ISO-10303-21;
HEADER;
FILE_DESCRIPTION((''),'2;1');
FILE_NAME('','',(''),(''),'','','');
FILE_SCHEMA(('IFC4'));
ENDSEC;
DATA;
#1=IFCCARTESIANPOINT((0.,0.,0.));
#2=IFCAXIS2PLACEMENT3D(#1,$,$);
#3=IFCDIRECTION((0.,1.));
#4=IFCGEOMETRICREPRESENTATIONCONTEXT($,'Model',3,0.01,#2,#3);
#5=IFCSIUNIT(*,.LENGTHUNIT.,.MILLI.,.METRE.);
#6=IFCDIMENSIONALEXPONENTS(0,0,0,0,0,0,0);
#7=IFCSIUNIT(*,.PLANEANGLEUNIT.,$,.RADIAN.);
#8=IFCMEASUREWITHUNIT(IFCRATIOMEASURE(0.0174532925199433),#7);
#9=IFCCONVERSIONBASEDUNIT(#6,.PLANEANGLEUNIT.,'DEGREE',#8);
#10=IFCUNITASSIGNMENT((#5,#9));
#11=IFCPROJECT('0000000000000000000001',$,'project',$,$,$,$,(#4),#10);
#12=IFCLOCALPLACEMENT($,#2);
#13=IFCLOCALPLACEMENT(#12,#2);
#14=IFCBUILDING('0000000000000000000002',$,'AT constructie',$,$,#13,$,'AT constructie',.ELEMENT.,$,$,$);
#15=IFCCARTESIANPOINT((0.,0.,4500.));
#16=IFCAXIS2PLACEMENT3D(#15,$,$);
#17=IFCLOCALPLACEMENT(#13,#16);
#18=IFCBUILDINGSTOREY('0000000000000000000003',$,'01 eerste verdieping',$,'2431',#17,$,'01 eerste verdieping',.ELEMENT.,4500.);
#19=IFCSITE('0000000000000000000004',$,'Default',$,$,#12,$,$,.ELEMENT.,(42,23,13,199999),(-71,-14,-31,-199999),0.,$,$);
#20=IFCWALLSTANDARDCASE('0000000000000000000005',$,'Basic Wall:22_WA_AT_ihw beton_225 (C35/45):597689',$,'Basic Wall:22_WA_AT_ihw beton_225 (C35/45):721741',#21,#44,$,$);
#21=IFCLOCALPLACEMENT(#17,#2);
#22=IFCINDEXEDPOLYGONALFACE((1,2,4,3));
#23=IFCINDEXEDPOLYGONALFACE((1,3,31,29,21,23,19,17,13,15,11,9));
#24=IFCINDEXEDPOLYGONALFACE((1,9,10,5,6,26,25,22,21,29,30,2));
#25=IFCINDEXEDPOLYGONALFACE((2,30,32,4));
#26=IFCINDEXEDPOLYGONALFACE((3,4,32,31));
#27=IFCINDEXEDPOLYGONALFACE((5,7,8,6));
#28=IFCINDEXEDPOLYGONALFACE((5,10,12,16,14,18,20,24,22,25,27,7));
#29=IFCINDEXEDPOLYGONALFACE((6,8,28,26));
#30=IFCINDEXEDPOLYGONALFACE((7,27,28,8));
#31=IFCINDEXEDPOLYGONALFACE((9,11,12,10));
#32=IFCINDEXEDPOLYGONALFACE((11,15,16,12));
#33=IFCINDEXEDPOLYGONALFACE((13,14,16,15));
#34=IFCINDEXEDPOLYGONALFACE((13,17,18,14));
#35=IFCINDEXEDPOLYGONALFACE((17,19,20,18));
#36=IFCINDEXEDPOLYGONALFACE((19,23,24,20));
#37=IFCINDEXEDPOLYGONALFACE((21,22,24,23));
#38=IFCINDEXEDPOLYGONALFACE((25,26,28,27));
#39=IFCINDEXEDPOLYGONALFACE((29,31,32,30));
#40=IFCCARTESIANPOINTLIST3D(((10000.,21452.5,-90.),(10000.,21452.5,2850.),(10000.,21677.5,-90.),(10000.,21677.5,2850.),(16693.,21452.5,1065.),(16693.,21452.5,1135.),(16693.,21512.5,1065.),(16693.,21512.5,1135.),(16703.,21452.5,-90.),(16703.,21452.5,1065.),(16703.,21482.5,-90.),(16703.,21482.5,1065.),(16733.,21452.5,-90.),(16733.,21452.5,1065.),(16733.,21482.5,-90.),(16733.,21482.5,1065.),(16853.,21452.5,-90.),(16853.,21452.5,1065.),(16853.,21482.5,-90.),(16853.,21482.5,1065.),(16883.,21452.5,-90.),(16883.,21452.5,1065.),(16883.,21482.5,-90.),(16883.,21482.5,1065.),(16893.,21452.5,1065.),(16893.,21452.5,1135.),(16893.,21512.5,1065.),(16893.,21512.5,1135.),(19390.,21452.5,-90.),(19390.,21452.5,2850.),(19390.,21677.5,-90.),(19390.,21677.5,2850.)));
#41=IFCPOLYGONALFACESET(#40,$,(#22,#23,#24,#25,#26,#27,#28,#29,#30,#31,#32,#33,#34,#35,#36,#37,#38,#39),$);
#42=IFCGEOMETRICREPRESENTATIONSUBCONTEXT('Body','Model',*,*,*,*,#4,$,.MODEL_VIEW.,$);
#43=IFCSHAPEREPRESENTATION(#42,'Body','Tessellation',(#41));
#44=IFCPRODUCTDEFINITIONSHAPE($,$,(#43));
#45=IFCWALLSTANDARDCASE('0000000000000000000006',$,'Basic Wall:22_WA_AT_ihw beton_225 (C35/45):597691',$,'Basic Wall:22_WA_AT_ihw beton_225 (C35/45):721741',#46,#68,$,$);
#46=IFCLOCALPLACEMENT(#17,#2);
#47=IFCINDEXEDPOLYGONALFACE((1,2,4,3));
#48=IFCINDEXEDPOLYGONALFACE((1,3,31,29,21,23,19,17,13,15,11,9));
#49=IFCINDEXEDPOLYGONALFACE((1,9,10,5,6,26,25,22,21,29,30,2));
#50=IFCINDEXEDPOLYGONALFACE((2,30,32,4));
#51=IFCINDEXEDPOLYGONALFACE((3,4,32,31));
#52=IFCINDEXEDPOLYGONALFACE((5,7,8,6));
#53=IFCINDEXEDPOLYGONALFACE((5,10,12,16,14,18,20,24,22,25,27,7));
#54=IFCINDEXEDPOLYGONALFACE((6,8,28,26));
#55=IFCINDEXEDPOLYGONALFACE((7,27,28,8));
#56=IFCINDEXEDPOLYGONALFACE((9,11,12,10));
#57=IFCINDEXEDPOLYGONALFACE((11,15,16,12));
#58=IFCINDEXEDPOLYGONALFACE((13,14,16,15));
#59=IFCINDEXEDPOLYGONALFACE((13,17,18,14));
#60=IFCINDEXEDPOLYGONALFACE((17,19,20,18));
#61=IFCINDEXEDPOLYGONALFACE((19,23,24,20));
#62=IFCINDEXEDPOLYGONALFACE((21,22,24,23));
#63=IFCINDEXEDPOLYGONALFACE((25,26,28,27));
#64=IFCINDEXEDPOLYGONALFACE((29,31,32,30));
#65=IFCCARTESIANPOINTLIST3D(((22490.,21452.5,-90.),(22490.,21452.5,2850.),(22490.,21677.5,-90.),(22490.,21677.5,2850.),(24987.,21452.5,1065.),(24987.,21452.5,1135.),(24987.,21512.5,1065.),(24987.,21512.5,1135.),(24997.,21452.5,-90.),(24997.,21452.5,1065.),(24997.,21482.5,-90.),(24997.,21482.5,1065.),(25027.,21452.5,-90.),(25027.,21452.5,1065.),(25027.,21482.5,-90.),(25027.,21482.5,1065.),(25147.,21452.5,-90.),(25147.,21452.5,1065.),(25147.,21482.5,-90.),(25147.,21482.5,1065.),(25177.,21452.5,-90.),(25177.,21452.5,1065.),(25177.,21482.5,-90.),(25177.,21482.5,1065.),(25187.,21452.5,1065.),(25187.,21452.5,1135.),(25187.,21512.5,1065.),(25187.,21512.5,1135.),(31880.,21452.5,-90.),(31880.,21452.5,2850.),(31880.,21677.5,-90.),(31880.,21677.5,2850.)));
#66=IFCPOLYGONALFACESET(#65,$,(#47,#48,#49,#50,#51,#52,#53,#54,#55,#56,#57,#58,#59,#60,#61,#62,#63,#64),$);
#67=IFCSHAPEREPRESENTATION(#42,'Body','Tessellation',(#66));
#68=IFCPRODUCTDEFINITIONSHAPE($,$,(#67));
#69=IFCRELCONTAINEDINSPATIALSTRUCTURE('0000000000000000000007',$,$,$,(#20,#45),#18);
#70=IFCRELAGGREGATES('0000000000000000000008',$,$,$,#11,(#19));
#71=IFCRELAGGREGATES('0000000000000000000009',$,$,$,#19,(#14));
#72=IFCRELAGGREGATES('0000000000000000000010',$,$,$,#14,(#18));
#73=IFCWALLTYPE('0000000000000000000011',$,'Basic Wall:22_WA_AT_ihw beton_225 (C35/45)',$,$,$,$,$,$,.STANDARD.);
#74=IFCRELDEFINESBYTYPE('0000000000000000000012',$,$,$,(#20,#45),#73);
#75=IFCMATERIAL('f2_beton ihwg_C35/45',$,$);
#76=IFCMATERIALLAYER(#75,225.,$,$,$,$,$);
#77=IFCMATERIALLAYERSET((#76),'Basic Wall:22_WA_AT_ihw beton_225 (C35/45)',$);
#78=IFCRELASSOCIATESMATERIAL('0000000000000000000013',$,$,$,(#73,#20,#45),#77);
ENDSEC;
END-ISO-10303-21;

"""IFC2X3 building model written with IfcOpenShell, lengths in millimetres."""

from ifc_helpers import new_model, entity, si_unit, converted_unit, direction, frame, frame_2d, origin, origin_2d_with_axis, place, context, subcontext, project, spatial, rectangle, extrude, material, layer, layer_set, layer_usage, type_object, element, save


model = new_model("IFC2X3")

# Units and contexts
model_context = context("Model", 3, precision=0.01, world=origin(), true_north=direction((0.0, 1.0)))
body_context = subcontext(model_context, "Body", "Model", "MODEL_VIEW")
ifc_project = project(units=[si_unit("LENGTHUNIT", "METRE", prefix="MILLI"), converted_unit("PLANEANGLEUNIT", "DEGREE", entity("IfcRatioMeasure", 0.0174532925199433), si_unit("PLANEANGLEUNIT", "RADIAN"), dimensions=[0, 0, 0, 0, 0, 0, 0])], contexts=[model_context])

# Site, building, storey
site_placement = place(None, origin())
site = spatial("IfcSite", under=ifc_project, at=site_placement, Name="Default", CompositionType="ELEMENT", RefLatitude=(42, 23, 13, 199999), RefLongitude=(-71, -14, -31, -199999), RefElevation=0.0)
building_placement = place(site_placement, origin())
building = spatial("IfcBuilding", under=site, at=building_placement, Name="AT constructie", LongName="AT constructie", CompositionType="ELEMENT")
storey_placement = place(building_placement, frame((0.0, 0.0, 4500.0)))
storey = spatial("IfcBuildingStorey", under=building, at=storey_placement, Name="01 eerste verdieping", ObjectType="2431", LongName="01 eerste verdieping", CompositionType="ELEMENT", Elevation=4500.0)

# Shared definitions
ifc_material_1 = material(Name="f2_beton ihwg_C35/45")

# Shared definitions
ifc_layer_1 = layer(ifc_material_1, 225.0)
ifc_layer_set_1 = layer_set([ifc_layer_1], Name="Basic Wall:22_WA_AT_ihw beton_225 (C35/45)")
wall_type_1 = type_object("IfcWallType", Name="Basic Wall:22_WA_AT_ihw beton_225 (C35/45)", PredefinedType="STANDARD", material=ifc_layer_set_1)

# Walls, openings
ifc_layer_usage_1 = layer_usage(ifc_layer_set_1, "AXIS2", "NEGATIVE", 112.5)
wall_1_placement = place(storey_placement, frame((10000.0, 21565.0, -90.0)))
wall_1 = element("IfcWallStandardCase", 1, at=wall_1_placement, inside=storey, type_object=wall_type_1, material=ifc_layer_usage_1, Name="Basic Wall:22_WA_AT_ihw beton_225 (C35/45):597689", ObjectType="Basic Wall:22_WA_AT_ihw beton_225 (C35/45):721741", context=body_context, shape_type="SweptSolid", body=[
    extrude(rectangle(XDim=9390.0, YDim=225.0, at=frame_2d((4695.0, 0.0), x_axis=(-1.0, 0.0))), origin(), (0.0, 0.0, 1.0), 2940.0),
])
opening_1_placement = place(wall_1_placement, origin())
element("IfcOpeningElement", 2, at=opening_1_placement, cuts=wall_1, ObjectType="Recess", context=body_context, shape_type="SweptSolid", body=[
    extrude(rectangle(XDim=1155.0, YDim=30.0, at=frame_2d((0.0, 0.0), x_axis=(1.0, 0.0))), frame((6718.0, -112.5, 577.5), z_axis=(0.0, 1.0, 0.0), x_axis=(0.0, 0.0, -1.0)), (0.0, 0.0, 1.0), 30.0),
])
opening_2_placement = place(wall_1_placement, origin())
element("IfcOpeningElement", 3, at=opening_2_placement, cuts=wall_1, ObjectType="Recess", context=body_context, shape_type="SweptSolid", body=[
    extrude(rectangle(XDim=1155.0, YDim=30.0, at=frame_2d((0.0, 0.0), x_axis=(1.0, 0.0))), frame((6868.0, -112.5, 577.5), z_axis=(0.0, 1.0, 0.0), x_axis=(0.0, 0.0, -1.0)), (0.0, 0.0, 1.0), 30.0),
])
opening_3_placement = place(wall_1_placement, origin())
element("IfcOpeningElement", 4, at=opening_3_placement, cuts=wall_1, ObjectType="Recess", context=body_context, shape_type="SweptSolid", body=[
    extrude(rectangle(XDim=70.0, YDim=200.0, at=origin_2d_with_axis()), frame((6793.0, -112.5, 1190.0), z_axis=(0.0, 1.0, 0.0), x_axis=(0.0, 0.0, -1.0)), (0.0, 0.0, 1.0), 60.0),
])
ifc_layer_usage_2 = layer_usage(ifc_layer_set_1, "AXIS2", "NEGATIVE", 112.5)
wall_2_placement = place(storey_placement, frame((22490.0, 21565.0, -90.0)))
wall_2 = element("IfcWallStandardCase", 5, at=wall_2_placement, inside=storey, type_object=wall_type_1, material=ifc_layer_usage_2, Name="Basic Wall:22_WA_AT_ihw beton_225 (C35/45):597691", ObjectType="Basic Wall:22_WA_AT_ihw beton_225 (C35/45):721741", context=body_context, shape_type="SweptSolid", body=[
    extrude(rectangle(XDim=9390.0, YDim=225.0, at=frame_2d((4695.0, 0.0), x_axis=(-1.0, 0.0))), origin(), (0.0, 0.0, 1.0), 2940.0),
])
opening_4_placement = place(wall_2_placement, origin())
element("IfcOpeningElement", 6, at=opening_4_placement, cuts=wall_2, ObjectType="Recess", context=body_context, shape_type="SweptSolid", body=[
    extrude(rectangle(XDim=1155.0, YDim=30.0, at=frame_2d((0.0, 0.0), x_axis=(1.0, 0.0))), frame((2522.0, -112.5, 577.5), z_axis=(0.0, 1.0, 0.0), x_axis=(0.0, 0.0, -1.0)), (0.0, 0.0, 1.0), 30.0),
])
opening_5_placement = place(wall_2_placement, origin())
element("IfcOpeningElement", 7, at=opening_5_placement, cuts=wall_2, ObjectType="Recess", context=body_context, shape_type="SweptSolid", body=[
    extrude(rectangle(XDim=1155.0, YDim=30.0, at=frame_2d((0.0, 0.0), x_axis=(1.0, 0.0))), frame((2672.0, -112.5, 577.5), z_axis=(0.0, 1.0, 0.0), x_axis=(0.0, 0.0, -1.0)), (0.0, 0.0, 1.0), 30.0),
])
opening_6_placement = place(wall_2_placement, origin())
element("IfcOpeningElement", 8, at=opening_6_placement, cuts=wall_2, ObjectType="Recess", context=body_context, shape_type="SweptSolid", body=[
    extrude(rectangle(XDim=70.0, YDim=200.0, at=origin_2d_with_axis()), frame((2597.0, -112.5, 1190.0), z_axis=(0.0, 1.0, 0.0), x_axis=(0.0, 0.0, -1.0)), (0.0, 0.0, 1.0), 60.0),
])

save(model, "model.ifc")
